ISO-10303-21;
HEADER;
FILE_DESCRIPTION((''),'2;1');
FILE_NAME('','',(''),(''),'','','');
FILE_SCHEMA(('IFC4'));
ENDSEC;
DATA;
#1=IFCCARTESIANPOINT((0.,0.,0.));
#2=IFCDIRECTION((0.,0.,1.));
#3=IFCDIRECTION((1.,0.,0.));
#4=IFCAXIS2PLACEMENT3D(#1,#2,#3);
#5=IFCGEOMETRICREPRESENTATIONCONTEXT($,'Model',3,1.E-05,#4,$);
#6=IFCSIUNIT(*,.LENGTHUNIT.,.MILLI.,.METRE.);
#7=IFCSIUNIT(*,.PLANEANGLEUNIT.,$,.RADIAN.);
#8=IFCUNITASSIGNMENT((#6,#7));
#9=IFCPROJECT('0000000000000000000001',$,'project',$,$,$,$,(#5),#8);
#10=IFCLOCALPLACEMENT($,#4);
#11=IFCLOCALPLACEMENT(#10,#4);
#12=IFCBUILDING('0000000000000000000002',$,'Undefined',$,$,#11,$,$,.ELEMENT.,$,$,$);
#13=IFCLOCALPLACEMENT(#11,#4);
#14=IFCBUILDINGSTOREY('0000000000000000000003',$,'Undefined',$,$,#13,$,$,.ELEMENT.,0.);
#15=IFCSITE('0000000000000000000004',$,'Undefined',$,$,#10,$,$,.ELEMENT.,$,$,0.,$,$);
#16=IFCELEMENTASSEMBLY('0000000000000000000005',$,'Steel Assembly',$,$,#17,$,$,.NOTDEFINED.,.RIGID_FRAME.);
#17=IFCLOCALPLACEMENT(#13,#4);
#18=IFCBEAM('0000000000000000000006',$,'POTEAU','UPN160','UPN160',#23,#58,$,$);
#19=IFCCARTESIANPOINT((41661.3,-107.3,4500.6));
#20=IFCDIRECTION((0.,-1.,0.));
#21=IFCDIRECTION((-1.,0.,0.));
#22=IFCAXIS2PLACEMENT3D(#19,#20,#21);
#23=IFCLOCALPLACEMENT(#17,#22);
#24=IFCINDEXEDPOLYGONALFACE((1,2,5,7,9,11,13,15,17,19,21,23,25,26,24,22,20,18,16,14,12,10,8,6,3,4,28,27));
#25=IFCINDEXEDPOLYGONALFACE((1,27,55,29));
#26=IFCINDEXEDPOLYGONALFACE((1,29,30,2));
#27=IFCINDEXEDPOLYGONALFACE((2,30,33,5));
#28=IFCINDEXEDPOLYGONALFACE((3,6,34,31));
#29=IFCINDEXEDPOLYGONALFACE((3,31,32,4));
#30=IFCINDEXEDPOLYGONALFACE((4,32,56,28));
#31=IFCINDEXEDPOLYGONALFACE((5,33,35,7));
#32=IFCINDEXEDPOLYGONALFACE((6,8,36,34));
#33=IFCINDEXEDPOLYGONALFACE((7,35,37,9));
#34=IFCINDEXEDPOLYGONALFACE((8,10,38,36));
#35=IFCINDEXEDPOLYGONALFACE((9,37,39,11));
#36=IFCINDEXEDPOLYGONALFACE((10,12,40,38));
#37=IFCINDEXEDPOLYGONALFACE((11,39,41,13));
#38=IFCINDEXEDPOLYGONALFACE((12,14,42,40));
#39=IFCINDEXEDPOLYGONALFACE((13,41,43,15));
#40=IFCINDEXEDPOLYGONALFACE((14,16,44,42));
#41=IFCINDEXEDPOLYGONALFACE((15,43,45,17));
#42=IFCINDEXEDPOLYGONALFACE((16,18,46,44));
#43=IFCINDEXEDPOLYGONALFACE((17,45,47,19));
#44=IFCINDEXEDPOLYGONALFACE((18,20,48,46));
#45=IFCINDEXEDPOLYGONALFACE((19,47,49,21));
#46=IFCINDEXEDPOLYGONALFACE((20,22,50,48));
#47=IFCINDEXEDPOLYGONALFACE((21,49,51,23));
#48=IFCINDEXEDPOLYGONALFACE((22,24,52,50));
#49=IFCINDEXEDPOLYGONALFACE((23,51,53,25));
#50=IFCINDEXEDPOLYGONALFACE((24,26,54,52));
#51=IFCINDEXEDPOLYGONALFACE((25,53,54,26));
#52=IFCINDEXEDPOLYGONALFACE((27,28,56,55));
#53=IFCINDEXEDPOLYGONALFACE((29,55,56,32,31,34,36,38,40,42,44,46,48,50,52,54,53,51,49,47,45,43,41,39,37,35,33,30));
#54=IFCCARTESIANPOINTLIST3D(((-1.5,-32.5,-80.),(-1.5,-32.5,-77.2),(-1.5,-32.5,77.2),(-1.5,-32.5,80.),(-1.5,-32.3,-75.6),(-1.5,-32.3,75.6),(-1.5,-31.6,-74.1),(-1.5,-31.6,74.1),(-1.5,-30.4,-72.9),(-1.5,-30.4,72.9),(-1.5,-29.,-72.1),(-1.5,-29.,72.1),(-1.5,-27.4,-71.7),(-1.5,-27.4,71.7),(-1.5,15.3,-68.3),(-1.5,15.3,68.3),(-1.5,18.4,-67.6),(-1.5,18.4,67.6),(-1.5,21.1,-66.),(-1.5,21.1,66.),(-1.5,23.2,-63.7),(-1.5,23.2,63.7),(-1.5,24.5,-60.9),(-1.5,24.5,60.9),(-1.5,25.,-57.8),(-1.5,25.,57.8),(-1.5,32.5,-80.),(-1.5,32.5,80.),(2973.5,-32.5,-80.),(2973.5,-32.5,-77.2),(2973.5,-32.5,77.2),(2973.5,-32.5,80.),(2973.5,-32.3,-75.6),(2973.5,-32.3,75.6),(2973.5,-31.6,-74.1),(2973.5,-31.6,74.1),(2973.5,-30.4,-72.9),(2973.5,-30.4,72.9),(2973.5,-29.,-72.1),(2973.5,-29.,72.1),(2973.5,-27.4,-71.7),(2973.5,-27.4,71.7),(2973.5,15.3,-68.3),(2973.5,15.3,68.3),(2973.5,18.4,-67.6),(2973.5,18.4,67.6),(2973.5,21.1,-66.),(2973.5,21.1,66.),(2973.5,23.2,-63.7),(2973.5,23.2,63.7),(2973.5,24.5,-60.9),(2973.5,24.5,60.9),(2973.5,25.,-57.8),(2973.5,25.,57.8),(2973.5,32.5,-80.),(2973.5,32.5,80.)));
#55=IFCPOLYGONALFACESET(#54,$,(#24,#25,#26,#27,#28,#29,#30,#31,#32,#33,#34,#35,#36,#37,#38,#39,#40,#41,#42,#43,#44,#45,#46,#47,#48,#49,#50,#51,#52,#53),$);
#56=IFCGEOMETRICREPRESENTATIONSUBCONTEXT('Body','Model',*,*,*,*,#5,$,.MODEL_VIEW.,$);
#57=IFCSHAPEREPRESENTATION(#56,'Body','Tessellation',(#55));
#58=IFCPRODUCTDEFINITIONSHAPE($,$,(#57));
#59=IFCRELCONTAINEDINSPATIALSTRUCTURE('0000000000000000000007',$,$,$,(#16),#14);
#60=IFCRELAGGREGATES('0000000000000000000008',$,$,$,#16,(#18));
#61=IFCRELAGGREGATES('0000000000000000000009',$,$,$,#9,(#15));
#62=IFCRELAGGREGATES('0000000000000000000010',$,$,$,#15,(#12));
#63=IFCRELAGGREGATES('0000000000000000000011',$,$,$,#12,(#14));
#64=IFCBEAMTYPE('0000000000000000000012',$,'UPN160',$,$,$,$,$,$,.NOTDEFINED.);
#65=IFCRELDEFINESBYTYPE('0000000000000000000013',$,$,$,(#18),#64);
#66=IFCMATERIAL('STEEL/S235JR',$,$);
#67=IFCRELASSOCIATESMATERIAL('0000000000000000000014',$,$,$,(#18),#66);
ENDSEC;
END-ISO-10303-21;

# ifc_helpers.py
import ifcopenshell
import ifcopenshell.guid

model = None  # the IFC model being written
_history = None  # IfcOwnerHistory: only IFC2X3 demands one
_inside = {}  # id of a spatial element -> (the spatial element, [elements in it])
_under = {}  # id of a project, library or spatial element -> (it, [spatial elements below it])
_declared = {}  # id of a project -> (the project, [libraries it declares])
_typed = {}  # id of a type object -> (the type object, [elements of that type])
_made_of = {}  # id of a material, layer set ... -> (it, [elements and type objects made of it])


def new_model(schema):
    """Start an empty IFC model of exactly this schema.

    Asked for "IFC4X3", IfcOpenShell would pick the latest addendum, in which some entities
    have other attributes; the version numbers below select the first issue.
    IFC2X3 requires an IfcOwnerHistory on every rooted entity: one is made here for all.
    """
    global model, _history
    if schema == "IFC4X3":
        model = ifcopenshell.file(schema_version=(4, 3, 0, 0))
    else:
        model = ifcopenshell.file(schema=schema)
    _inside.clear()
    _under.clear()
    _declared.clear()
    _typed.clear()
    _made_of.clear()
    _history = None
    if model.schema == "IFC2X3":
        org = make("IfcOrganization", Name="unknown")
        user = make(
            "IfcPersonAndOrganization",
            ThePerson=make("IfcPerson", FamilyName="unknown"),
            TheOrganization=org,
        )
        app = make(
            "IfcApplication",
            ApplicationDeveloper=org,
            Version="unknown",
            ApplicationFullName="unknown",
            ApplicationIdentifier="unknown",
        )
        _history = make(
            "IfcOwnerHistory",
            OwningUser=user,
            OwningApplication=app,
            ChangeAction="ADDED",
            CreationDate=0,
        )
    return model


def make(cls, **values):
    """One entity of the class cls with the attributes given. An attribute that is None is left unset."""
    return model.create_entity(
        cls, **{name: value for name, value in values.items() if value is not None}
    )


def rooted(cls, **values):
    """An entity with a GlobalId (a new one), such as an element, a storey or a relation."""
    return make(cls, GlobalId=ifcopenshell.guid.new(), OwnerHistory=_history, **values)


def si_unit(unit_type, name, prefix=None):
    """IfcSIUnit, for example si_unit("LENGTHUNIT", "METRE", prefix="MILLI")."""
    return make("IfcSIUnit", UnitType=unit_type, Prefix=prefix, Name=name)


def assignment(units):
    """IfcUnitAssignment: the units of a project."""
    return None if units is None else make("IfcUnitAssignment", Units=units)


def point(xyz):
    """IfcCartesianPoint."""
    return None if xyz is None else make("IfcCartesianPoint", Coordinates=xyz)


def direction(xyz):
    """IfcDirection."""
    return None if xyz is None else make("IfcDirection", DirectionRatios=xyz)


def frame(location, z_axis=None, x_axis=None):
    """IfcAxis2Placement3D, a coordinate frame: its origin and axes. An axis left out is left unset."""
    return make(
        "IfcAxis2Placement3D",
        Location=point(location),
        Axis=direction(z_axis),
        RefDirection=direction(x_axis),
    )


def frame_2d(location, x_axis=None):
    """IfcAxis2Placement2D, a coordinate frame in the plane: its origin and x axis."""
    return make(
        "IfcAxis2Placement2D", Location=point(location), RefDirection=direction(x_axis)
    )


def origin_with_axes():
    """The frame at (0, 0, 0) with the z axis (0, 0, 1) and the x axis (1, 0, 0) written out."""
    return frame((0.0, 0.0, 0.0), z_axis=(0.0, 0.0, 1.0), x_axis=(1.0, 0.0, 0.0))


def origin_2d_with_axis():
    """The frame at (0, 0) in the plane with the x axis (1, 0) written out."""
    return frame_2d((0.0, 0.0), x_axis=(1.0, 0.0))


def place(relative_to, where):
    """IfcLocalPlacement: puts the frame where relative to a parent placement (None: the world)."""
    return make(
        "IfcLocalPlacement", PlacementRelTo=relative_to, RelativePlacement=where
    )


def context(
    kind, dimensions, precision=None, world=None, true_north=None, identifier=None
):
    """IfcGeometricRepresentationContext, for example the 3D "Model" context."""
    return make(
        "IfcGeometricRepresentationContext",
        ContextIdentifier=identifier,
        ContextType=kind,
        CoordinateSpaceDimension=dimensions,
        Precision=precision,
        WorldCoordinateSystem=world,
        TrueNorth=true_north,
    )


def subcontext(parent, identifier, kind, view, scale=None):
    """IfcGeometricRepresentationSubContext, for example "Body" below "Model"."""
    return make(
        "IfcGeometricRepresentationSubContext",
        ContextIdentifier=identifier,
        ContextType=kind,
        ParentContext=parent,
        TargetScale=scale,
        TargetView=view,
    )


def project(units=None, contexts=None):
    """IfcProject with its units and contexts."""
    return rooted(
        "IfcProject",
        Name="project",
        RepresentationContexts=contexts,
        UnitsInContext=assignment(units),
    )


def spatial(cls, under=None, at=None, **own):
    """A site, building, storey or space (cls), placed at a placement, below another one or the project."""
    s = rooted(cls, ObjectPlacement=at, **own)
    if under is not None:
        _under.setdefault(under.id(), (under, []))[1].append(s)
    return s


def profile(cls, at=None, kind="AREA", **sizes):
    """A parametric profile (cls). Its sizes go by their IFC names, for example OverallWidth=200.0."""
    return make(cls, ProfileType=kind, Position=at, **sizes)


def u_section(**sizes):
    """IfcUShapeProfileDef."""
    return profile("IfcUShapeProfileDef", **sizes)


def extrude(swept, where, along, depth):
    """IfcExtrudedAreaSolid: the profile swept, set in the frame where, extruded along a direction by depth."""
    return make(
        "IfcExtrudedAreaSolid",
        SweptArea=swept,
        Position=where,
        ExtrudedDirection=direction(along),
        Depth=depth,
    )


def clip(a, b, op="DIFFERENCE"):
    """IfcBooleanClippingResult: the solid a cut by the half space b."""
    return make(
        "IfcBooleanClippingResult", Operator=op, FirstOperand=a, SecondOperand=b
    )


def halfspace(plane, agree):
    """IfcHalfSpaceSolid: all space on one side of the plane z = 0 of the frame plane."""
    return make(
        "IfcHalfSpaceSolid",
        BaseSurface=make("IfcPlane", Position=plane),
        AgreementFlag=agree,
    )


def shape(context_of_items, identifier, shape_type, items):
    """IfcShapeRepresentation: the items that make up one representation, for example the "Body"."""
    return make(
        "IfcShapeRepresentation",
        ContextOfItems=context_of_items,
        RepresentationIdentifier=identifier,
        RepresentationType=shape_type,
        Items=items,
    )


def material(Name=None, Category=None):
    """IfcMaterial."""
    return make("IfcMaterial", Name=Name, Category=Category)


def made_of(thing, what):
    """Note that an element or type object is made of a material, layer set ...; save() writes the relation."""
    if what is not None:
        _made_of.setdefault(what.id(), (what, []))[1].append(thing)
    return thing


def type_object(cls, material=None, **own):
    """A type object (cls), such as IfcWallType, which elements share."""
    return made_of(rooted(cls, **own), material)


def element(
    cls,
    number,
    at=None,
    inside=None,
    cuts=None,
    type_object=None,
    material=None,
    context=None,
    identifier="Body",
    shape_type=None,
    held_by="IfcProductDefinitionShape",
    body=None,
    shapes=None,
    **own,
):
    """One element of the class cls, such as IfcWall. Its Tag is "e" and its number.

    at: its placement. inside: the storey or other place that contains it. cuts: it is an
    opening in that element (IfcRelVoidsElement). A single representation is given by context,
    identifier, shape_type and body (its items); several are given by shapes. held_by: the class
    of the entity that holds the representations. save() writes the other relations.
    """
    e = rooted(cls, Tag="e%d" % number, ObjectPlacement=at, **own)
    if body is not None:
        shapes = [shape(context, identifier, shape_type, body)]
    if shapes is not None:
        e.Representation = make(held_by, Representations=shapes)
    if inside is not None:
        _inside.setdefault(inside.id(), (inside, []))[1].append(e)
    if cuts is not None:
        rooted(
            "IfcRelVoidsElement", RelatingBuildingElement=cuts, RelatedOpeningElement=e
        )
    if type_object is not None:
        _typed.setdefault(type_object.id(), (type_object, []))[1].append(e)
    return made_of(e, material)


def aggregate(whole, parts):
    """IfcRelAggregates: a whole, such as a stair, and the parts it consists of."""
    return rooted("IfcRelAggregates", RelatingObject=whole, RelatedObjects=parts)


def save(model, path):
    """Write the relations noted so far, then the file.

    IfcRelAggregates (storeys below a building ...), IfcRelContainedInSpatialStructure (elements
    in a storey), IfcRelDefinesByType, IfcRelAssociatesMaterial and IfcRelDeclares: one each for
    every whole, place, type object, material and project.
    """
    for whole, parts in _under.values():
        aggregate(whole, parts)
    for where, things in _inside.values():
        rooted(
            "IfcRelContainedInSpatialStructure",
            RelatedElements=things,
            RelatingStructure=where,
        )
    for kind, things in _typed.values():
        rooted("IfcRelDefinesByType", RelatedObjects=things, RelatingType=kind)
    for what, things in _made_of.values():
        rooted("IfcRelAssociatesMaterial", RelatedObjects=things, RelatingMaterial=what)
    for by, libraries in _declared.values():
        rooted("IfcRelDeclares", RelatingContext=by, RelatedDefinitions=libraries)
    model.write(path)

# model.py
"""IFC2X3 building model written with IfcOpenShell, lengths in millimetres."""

from ifc_helpers import new_model, si_unit, frame, origin_with_axes, origin_2d_with_axis, place, context, subcontext, project, spatial, u_section, extrude, clip, halfspace, material, type_object, element, aggregate, save


model = new_model("IFC2X3")

# Units and contexts
model_context = context("Model", 3, precision=1e-05, world=origin_with_axes())
body_context = subcontext(model_context, "Body", "Model", "MODEL_VIEW")
ifc_project = project(units=[si_unit("LENGTHUNIT", "METRE", prefix="MILLI"), si_unit("PLANEANGLEUNIT", "RADIAN")], contexts=[model_context])

# Site, building, storey
site_placement = place(None, origin_with_axes())
site = spatial("IfcSite", under=ifc_project, at=site_placement, Name="Undefined", CompositionType="ELEMENT", RefElevation=0.0)
building_placement = place(site_placement, origin_with_axes())
building = spatial("IfcBuilding", under=site, at=building_placement, Name="Undefined", CompositionType="ELEMENT")
storey_placement = place(building_placement, origin_with_axes())
storey = spatial("IfcBuildingStorey", under=building, at=storey_placement, Name="Undefined", CompositionType="ELEMENT", Elevation=0.0)

# Element assembly, beam
ifc_material_1 = material(Name="STEEL/S235JR")
assembly_1_placement = place(storey_placement, origin_with_axes())
assembly_1 = element("IfcElementAssembly", 1, at=assembly_1_placement, inside=storey, Name="Steel Assembly", AssemblyPlace="NOTDEFINED", PredefinedType="RIGID_FRAME")
beam_type_1 = type_object("IfcBeamType", Name="UPN160", PredefinedType="NOTDEFINED")
beam_1_placement = place(assembly_1_placement, frame((41661.3, -107.3, 4500.6), z_axis=(0.0, -1.0, 0.0), x_axis=(-1.0, 0.0, 0.0)))
beam_1 = element("IfcBeam", 2, at=beam_1_placement, type_object=beam_type_1, material=ifc_material_1, Name="POTEAU", Description="UPN160", ObjectType="UPN160", context=body_context, shape_type="Clipping", body=[
    clip(clip(clip(extrude(u_section(Depth=160.0, FlangeWidth=65.0, WebThickness=7.5, FlangeThickness=10.5, FilletRadius=10.5, EdgeRadius=5.5, FlangeSlope=0.07983, at=origin_2d_with_axis()), frame((3058.5, 0.0, 0.0), z_axis=(-1.0, 0.0, 0.0), x_axis=(0.0, -1.0, 0.0)), (0.0, 0.0, 1.0), 3060.0), halfspace(frame((2973.5, -32.5, -80.0), z_axis=(1.0, 0.0, 0.0), x_axis=(0.0, 0.0, 1.0)), False)), halfspace(frame((3058.5, 0.0, 80.0), z_axis=(1.0, 0.0, 0.0), x_axis=(0.0, 1.0, 0.0)), False)), halfspace(frame((-1.5, 0.0, 80.0), z_axis=(-1.0, 0.0, 0.0), x_axis=(0.0, -1.0, 0.0)), False)),
])

aggregate(assembly_1, [beam_1])

save(model, "model.ifc")
